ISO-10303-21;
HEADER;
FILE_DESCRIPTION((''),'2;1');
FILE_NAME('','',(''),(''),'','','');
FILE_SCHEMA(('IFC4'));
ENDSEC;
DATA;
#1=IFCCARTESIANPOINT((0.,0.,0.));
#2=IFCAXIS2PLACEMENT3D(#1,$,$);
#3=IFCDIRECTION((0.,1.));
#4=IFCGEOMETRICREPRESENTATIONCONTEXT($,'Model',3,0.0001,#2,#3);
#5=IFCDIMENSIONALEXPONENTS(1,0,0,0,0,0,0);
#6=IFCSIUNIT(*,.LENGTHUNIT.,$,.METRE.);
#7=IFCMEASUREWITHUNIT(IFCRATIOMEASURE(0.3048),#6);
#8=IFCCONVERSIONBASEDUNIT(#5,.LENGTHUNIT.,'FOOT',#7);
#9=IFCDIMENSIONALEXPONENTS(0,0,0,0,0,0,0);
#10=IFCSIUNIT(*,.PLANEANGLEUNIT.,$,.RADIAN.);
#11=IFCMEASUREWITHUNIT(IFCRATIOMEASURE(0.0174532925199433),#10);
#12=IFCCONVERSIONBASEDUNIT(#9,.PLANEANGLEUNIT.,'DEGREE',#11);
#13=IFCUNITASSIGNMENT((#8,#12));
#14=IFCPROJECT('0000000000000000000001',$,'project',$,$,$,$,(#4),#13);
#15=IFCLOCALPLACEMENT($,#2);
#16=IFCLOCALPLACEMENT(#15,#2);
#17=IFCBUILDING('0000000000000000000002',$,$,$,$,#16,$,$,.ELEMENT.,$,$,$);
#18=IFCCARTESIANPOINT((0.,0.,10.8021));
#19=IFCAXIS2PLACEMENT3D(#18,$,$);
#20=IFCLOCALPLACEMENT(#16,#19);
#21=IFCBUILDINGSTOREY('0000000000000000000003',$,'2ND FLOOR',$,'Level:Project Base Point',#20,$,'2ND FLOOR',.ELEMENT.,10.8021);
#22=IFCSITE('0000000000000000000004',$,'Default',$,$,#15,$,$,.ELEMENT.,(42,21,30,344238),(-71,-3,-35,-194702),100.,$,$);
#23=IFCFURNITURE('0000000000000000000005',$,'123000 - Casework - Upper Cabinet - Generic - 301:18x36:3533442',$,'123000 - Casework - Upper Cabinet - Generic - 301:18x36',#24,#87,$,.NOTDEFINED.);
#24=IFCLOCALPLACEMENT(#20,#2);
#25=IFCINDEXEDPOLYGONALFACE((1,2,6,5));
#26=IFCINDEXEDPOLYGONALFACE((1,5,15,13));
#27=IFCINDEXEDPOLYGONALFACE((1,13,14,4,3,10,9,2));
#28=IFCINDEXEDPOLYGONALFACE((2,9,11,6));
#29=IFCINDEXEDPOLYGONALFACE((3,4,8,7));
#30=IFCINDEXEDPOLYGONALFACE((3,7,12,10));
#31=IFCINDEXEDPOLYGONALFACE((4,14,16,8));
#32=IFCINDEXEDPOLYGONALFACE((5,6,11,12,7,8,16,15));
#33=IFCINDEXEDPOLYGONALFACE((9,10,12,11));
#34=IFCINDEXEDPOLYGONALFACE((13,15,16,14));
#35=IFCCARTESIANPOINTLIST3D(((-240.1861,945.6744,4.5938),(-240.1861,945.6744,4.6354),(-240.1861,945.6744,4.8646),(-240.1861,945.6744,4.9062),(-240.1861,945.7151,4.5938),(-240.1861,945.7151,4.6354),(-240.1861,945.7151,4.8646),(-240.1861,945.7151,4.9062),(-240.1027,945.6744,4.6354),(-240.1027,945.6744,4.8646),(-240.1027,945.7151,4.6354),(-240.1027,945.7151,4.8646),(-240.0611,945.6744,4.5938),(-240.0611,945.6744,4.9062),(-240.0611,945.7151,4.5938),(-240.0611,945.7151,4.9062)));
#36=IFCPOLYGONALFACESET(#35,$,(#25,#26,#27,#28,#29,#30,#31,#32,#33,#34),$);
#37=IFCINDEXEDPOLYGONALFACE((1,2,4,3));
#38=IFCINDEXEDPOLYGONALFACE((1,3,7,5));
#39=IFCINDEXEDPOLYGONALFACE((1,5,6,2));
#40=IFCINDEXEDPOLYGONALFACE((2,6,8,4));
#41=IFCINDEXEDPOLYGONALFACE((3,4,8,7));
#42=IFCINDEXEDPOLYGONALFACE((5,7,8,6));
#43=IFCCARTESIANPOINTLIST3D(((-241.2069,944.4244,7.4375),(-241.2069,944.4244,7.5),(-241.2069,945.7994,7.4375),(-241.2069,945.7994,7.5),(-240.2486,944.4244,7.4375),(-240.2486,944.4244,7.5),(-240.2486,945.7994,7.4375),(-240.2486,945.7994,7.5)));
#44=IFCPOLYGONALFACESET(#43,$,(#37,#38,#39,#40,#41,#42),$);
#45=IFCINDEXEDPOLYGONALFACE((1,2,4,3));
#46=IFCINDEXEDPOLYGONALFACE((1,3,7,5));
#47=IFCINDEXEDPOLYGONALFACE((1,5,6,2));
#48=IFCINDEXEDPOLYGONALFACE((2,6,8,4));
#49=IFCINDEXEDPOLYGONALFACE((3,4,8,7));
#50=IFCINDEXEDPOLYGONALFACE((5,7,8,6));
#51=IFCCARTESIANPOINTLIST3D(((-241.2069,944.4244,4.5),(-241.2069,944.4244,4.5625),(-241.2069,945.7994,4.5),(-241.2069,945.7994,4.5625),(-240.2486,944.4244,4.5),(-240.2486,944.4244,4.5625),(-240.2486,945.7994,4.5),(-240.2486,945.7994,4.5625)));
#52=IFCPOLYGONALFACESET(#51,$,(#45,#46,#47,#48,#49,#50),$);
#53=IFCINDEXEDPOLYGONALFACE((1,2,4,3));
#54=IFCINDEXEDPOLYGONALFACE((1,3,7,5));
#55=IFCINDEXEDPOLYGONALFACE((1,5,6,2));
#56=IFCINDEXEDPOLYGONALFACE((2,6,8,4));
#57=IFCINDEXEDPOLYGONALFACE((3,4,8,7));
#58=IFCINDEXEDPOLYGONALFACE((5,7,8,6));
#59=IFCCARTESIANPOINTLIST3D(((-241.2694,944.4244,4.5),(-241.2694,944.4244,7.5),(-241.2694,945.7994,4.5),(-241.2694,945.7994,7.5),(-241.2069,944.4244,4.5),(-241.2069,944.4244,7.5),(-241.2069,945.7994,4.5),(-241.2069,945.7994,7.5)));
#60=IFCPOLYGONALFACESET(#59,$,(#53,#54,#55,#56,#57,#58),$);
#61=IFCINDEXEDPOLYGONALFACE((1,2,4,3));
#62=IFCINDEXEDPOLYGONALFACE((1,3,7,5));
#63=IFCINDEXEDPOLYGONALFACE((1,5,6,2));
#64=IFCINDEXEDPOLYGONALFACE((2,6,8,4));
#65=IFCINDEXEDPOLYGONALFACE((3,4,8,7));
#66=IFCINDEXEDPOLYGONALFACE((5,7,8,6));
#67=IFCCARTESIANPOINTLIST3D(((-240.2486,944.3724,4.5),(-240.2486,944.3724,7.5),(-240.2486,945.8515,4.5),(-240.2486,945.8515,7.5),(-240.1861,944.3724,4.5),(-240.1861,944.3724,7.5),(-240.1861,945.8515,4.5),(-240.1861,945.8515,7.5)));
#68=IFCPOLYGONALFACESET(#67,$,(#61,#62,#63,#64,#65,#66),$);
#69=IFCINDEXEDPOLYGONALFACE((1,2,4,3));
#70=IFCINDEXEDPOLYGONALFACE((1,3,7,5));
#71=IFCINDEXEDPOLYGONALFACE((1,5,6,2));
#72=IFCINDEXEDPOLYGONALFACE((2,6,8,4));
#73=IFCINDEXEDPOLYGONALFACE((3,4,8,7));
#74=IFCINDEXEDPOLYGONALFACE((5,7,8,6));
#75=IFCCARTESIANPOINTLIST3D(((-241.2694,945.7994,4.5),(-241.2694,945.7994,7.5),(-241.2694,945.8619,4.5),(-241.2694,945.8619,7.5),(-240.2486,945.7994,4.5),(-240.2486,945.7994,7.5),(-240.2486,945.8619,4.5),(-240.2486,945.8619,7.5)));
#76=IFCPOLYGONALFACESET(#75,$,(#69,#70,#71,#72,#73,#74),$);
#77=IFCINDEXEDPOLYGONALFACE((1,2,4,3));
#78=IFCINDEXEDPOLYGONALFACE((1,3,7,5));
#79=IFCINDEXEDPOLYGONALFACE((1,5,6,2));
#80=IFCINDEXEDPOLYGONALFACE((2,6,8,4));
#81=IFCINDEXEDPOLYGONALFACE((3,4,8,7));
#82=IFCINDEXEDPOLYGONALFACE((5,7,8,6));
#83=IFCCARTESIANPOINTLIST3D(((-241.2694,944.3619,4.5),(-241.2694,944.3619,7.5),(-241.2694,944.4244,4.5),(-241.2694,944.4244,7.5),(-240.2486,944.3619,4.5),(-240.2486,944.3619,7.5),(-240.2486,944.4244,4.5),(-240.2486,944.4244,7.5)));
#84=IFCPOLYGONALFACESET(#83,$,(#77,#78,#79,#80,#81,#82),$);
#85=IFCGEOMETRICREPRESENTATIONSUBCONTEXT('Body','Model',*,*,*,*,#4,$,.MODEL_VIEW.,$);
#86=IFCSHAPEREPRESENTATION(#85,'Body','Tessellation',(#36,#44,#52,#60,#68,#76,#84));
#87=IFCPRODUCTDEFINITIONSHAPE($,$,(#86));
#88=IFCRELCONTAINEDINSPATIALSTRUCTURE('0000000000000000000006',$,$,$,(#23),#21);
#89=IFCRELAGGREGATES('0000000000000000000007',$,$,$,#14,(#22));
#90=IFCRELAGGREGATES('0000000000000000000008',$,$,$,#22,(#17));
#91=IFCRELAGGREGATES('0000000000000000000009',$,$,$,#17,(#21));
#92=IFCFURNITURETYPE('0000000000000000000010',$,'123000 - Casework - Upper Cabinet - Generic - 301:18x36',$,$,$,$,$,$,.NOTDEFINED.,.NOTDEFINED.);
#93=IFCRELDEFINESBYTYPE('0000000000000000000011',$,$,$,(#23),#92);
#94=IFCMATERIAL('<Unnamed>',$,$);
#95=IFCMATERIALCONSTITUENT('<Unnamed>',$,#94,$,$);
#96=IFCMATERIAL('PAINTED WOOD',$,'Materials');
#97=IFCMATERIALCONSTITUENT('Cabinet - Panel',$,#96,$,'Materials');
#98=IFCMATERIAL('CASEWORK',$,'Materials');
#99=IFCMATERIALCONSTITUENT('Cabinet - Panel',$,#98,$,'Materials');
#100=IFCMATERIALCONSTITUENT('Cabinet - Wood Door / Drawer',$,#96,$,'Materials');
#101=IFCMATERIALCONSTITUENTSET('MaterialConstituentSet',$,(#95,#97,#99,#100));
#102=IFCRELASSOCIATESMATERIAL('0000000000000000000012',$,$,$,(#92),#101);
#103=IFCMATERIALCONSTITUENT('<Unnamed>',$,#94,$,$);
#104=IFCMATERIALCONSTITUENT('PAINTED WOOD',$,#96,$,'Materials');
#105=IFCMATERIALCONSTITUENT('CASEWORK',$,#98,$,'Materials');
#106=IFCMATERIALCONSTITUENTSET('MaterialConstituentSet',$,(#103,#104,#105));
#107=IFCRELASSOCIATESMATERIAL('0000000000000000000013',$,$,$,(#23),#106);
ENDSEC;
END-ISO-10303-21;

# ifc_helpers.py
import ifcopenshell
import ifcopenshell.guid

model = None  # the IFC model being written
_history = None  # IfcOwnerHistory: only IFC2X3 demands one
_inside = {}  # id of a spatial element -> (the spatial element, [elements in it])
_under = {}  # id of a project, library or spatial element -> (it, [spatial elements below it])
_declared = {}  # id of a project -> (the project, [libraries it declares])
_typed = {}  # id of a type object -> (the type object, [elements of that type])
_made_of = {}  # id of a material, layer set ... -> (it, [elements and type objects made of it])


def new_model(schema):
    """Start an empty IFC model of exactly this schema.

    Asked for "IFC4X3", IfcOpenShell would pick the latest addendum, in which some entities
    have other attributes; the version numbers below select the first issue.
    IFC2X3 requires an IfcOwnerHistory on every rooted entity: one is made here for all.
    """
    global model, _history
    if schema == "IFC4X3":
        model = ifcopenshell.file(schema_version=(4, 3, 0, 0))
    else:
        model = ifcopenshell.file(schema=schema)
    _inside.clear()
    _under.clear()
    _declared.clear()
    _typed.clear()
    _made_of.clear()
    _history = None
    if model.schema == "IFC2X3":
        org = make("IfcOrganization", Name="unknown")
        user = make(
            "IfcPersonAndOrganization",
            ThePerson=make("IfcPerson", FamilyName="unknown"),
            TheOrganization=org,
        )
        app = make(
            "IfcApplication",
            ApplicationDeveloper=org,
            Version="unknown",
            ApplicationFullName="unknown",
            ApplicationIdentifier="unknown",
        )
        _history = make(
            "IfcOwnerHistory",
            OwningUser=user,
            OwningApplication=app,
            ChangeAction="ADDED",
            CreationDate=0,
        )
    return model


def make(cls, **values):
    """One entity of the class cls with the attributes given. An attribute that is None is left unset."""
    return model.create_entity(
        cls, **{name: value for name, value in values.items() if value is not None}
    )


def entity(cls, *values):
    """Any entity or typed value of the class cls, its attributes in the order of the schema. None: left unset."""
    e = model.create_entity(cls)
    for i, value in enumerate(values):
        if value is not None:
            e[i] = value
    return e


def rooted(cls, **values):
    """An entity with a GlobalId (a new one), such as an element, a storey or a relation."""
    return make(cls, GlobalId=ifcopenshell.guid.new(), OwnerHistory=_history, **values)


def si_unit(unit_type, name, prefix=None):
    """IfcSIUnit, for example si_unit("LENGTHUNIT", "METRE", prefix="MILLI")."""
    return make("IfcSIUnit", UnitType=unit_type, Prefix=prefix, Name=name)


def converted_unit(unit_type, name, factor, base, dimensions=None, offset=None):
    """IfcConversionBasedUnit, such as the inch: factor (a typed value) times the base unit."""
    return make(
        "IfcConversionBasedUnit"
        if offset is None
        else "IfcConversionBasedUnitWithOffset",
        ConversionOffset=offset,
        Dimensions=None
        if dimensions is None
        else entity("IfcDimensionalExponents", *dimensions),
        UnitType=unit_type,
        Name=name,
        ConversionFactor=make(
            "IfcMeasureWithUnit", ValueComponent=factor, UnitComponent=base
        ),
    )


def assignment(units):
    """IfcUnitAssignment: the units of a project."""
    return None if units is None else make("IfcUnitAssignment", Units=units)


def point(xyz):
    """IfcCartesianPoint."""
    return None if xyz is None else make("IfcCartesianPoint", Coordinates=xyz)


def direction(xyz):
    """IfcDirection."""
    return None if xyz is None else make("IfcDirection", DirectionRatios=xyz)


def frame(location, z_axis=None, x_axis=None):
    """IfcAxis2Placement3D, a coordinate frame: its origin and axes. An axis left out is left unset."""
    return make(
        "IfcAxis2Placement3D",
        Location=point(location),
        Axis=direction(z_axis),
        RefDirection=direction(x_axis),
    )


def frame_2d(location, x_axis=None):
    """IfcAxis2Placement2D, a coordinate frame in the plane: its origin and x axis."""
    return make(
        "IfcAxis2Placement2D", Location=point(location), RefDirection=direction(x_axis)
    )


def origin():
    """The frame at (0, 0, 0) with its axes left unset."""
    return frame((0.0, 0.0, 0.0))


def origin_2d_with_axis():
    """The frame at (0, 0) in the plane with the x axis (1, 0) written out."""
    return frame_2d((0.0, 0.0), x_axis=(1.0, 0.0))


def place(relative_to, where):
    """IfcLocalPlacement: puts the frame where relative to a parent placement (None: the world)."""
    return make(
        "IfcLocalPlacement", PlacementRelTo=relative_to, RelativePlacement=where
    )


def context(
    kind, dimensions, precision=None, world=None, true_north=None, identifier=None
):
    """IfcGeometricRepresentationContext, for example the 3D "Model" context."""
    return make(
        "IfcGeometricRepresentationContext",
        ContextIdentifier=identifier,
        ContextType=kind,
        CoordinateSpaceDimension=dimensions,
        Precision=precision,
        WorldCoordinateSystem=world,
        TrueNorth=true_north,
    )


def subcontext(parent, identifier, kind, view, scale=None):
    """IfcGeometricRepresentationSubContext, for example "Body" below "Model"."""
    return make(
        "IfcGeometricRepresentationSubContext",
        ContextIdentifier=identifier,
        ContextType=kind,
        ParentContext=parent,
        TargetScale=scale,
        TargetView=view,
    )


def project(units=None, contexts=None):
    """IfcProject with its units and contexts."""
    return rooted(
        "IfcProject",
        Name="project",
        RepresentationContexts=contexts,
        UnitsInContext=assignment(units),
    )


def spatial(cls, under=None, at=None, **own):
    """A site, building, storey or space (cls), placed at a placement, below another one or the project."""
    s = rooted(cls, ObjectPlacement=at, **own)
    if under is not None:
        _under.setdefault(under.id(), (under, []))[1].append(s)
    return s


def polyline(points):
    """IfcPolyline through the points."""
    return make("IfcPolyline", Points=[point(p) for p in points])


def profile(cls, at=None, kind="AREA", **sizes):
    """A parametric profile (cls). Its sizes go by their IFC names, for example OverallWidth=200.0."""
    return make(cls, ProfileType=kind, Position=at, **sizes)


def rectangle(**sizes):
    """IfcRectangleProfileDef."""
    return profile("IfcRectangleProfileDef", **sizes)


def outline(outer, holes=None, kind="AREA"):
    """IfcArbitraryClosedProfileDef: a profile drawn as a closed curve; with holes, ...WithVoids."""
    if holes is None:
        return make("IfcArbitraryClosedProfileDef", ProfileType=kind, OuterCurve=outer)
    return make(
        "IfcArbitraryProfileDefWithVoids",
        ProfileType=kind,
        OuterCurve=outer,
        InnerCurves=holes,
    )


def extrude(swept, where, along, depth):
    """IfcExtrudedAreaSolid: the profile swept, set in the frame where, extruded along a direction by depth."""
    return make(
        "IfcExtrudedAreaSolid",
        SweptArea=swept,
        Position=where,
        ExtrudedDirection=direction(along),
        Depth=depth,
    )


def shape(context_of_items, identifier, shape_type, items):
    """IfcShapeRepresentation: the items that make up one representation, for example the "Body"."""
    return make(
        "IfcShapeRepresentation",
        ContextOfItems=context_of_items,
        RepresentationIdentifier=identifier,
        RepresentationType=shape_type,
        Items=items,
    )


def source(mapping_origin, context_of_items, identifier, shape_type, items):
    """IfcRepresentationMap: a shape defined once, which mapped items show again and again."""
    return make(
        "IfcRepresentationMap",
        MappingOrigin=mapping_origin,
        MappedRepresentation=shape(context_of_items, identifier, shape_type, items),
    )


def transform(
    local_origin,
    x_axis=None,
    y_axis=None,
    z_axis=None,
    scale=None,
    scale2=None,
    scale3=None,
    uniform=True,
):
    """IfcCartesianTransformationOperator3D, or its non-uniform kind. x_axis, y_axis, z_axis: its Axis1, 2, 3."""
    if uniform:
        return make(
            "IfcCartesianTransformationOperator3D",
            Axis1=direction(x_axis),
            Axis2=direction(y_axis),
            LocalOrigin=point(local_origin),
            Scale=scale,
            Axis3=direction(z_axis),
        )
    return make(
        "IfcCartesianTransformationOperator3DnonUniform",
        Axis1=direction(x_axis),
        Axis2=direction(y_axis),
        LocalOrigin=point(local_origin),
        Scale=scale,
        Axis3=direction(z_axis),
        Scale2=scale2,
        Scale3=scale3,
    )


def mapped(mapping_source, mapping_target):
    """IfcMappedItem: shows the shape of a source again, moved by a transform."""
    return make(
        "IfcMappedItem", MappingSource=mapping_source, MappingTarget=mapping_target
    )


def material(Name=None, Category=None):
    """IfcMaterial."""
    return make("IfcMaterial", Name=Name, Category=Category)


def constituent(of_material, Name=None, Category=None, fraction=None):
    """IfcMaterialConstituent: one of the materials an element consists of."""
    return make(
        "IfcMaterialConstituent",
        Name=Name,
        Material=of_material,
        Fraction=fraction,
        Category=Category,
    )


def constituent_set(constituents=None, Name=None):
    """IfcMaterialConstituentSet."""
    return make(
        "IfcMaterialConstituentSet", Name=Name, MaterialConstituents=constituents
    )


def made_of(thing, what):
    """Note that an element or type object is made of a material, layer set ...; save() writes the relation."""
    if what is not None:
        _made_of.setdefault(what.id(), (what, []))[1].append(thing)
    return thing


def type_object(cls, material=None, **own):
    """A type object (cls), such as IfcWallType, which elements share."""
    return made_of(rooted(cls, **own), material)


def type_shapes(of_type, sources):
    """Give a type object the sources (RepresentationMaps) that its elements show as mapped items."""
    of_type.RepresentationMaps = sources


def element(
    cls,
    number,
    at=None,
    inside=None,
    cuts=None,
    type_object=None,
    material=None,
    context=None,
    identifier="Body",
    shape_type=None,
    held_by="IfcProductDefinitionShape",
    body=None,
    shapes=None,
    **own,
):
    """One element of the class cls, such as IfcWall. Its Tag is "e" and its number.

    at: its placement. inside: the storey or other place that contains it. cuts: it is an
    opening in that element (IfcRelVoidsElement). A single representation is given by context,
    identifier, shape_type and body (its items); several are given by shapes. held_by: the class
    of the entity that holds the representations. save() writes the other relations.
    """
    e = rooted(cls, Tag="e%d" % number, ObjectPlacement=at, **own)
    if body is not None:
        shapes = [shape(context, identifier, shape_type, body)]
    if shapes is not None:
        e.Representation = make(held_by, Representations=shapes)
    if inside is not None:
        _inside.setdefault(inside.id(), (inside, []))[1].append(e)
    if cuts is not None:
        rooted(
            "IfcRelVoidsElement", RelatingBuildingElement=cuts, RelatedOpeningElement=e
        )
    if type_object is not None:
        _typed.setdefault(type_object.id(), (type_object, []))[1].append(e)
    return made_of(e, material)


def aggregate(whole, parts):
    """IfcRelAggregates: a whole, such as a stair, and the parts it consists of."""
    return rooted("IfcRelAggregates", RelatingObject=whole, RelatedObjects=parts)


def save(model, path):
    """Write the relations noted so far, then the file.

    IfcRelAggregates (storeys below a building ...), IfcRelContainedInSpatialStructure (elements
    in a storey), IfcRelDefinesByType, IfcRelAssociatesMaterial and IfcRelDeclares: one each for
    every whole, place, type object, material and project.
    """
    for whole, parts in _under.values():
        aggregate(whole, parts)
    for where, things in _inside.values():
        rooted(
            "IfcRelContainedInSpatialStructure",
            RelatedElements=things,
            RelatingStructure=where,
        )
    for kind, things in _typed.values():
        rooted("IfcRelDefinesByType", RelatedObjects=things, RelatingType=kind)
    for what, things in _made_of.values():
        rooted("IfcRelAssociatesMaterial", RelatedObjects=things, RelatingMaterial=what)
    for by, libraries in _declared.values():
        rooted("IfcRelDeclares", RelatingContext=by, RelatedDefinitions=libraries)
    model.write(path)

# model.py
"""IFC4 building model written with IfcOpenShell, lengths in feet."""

from ifc_helpers import new_model, entity, si_unit, converted_unit, direction, frame, frame_2d, origin, origin_2d_with_axis, place, context, subcontext, project, spatial, polyline, rectangle, outline, extrude, source, transform, mapped, material, constituent, constituent_set, type_object, type_shapes, element, save


model = new_model("IFC4")

# Units and contexts
model_context = context("Model", 3, precision=0.0001, world=origin(), true_north=direction((0.0, 1.0)))
body_context = subcontext(model_context, "Body", "Model", "MODEL_VIEW")
ifc_project = project(units=[converted_unit("LENGTHUNIT", "FOOT", entity("IfcRatioMeasure", 0.3048), si_unit("LENGTHUNIT", "METRE"), dimensions=[1, 0, 0, 0, 0, 0, 0]), converted_unit("PLANEANGLEUNIT", "DEGREE", entity("IfcRatioMeasure", 0.0174532925199433), si_unit("PLANEANGLEUNIT", "RADIAN"), dimensions=[0, 0, 0, 0, 0, 0, 0])], contexts=[model_context])

# Site, building, storey
site_placement = place(None, origin())
site = spatial("IfcSite", under=ifc_project, at=site_placement, Name="Default", CompositionType="ELEMENT", RefLatitude=(42, 21, 30, 344238), RefLongitude=(-71, -3, -35, -194702), RefElevation=100.0)
building_placement = place(site_placement, origin())
building = spatial("IfcBuilding", under=site, at=building_placement, CompositionType="ELEMENT")
storey_placement = place(building_placement, frame((0.0, 0.0, 10.8021)))
storey = spatial("IfcBuildingStorey", under=building, at=storey_placement, Name="2ND FLOOR", ObjectType="Level:Project Base Point", LongName="2ND FLOOR", CompositionType="ELEMENT", Elevation=10.8021)

# Shared definitions
ifc_material_1 = material(Name="PAINTED WOOD", Category="Materials")
ifc_material_2 = material(Name="CASEWORK", Category="Materials")

# Furniture
ifc_material_3 = material(Name="<Unnamed>")
ifc_constituent_1 = constituent(ifc_material_3, Name="<Unnamed>")
ifc_constituent_2 = constituent(ifc_material_1, Name="PAINTED WOOD", Category="Materials")
ifc_constituent_3 = constituent(ifc_material_2, Name="CASEWORK", Category="Materials")
ifc_constituent_set_1 = constituent_set(constituents=[ifc_constituent_1, ifc_constituent_2, ifc_constituent_3], Name="MaterialConstituentSet")
ifc_constituent_4 = constituent(ifc_material_3, Name="<Unnamed>")
ifc_constituent_5 = constituent(ifc_material_1, Name="Cabinet - Panel", Category="Materials")
ifc_constituent_6 = constituent(ifc_material_2, Name="Cabinet - Panel", Category="Materials")
ifc_constituent_7 = constituent(ifc_material_1, Name="Cabinet - Wood Door / Drawer", Category="Materials")
ifc_constituent_set_2 = constituent_set(constituents=[ifc_constituent_4, ifc_constituent_5, ifc_constituent_6, ifc_constituent_7], Name="MaterialConstituentSet")
furniture_type_1 = type_object("IfcFurnitureType", Name="123000 - Casework - Upper Cabinet - Generic - 301:18x36", AssemblyPlace="NOTDEFINED", PredefinedType="NOTDEFINED", material=ifc_constituent_set_2)
shared_shape_1 = source(origin(), body_context, "Body", "SweptSolid", [
    extrude(outline(polyline([(-0.0521, -0.1146), (-0.0521, -0.1562), (0.0729, -0.1562), (0.0729, 0.1562), (-0.0521, 0.1562), (-0.0521, 0.1146), (0.0313, 0.1146), (0.0313, -0.1146), (-0.0521, -0.1146)])), frame((0.1468, 1.1354, 0.25), z_axis=(-1.0, 0.0, 0.0), x_axis=(0.0, 1.0, 0.0)), (0.0, 0.0, -1.0), 0.0407),
    extrude(rectangle(XDim=0.9583, YDim=1.375, at=frame_2d((0.0, 0.0), x_axis=(1.0, 0.0))), frame((0.75, 0.5417, 2.9375), z_axis=(0.0, 0.0, 1.0), x_axis=(0.0, 1.0, 0.0)), (0.0, 0.0, 1.0), 0.0625),
    extrude(rectangle(XDim=0.9583, YDim=1.375, at=frame_2d((0.0, 0.0), x_axis=(1.0, 0.0))), frame((0.75, 0.5417, 0.0), z_axis=(0.0, 0.0, 1.0), x_axis=(0.0, 1.0, 0.0)), (0.0, 0.0, 1.0), 0.0625),
    extrude(rectangle(XDim=1.375, YDim=0.0625, at=origin_2d_with_axis()), frame((0.75, 0.0313, 0.0), z_axis=(0.0, 0.0, 1.0), x_axis=(-1.0, 0.0, 0.0)), (0.0, 0.0, 1.0), 3.0),
    extrude(rectangle(XDim=1.4792, YDim=0.0625, at=origin_2d_with_axis()), frame((0.75, 1.0521, 0.0)), (0.0, 0.0, 1.0), 3.0),
    extrude(rectangle(XDim=1.0208, YDim=0.0625, at=origin_2d_with_axis()), frame((0.0312, 0.5104, 0.0), z_axis=(0.0, 0.0, 1.0), x_axis=(0.0, 1.0, 0.0)), (0.0, 0.0, 1.0), 3.0),
    extrude(rectangle(XDim=1.0208, YDim=0.0625, at=origin_2d_with_axis()), frame((1.4688, 0.5104, 0.0), z_axis=(0.0, 0.0, 1.0), x_axis=(0.0, 1.0, 0.0)), (0.0, 0.0, 1.0), 3.0),
])
type_shapes(furniture_type_1, [shared_shape_1])
furniture_1_placement = place(storey_placement, frame((-241.2694, 945.8619, 4.5), z_axis=(0.0, 0.0, 1.0), x_axis=(0.0, -1.0, 0.0)))
element("IfcFurniture", 1, at=furniture_1_placement, inside=storey, type_object=furniture_type_1, material=ifc_constituent_set_1, Name="123000 - Casework - Upper Cabinet - Generic - 301:18x36:3533442", ObjectType="123000 - Casework - Upper Cabinet - Generic - 301:18x36", PredefinedType="NOTDEFINED", context=body_context, shape_type="MappedRepresentation", body=[
    mapped(shared_shape_1, transform((0.0, 0.0, 0.0), scale=1.0)),
])

save(model, "model.ifc")
